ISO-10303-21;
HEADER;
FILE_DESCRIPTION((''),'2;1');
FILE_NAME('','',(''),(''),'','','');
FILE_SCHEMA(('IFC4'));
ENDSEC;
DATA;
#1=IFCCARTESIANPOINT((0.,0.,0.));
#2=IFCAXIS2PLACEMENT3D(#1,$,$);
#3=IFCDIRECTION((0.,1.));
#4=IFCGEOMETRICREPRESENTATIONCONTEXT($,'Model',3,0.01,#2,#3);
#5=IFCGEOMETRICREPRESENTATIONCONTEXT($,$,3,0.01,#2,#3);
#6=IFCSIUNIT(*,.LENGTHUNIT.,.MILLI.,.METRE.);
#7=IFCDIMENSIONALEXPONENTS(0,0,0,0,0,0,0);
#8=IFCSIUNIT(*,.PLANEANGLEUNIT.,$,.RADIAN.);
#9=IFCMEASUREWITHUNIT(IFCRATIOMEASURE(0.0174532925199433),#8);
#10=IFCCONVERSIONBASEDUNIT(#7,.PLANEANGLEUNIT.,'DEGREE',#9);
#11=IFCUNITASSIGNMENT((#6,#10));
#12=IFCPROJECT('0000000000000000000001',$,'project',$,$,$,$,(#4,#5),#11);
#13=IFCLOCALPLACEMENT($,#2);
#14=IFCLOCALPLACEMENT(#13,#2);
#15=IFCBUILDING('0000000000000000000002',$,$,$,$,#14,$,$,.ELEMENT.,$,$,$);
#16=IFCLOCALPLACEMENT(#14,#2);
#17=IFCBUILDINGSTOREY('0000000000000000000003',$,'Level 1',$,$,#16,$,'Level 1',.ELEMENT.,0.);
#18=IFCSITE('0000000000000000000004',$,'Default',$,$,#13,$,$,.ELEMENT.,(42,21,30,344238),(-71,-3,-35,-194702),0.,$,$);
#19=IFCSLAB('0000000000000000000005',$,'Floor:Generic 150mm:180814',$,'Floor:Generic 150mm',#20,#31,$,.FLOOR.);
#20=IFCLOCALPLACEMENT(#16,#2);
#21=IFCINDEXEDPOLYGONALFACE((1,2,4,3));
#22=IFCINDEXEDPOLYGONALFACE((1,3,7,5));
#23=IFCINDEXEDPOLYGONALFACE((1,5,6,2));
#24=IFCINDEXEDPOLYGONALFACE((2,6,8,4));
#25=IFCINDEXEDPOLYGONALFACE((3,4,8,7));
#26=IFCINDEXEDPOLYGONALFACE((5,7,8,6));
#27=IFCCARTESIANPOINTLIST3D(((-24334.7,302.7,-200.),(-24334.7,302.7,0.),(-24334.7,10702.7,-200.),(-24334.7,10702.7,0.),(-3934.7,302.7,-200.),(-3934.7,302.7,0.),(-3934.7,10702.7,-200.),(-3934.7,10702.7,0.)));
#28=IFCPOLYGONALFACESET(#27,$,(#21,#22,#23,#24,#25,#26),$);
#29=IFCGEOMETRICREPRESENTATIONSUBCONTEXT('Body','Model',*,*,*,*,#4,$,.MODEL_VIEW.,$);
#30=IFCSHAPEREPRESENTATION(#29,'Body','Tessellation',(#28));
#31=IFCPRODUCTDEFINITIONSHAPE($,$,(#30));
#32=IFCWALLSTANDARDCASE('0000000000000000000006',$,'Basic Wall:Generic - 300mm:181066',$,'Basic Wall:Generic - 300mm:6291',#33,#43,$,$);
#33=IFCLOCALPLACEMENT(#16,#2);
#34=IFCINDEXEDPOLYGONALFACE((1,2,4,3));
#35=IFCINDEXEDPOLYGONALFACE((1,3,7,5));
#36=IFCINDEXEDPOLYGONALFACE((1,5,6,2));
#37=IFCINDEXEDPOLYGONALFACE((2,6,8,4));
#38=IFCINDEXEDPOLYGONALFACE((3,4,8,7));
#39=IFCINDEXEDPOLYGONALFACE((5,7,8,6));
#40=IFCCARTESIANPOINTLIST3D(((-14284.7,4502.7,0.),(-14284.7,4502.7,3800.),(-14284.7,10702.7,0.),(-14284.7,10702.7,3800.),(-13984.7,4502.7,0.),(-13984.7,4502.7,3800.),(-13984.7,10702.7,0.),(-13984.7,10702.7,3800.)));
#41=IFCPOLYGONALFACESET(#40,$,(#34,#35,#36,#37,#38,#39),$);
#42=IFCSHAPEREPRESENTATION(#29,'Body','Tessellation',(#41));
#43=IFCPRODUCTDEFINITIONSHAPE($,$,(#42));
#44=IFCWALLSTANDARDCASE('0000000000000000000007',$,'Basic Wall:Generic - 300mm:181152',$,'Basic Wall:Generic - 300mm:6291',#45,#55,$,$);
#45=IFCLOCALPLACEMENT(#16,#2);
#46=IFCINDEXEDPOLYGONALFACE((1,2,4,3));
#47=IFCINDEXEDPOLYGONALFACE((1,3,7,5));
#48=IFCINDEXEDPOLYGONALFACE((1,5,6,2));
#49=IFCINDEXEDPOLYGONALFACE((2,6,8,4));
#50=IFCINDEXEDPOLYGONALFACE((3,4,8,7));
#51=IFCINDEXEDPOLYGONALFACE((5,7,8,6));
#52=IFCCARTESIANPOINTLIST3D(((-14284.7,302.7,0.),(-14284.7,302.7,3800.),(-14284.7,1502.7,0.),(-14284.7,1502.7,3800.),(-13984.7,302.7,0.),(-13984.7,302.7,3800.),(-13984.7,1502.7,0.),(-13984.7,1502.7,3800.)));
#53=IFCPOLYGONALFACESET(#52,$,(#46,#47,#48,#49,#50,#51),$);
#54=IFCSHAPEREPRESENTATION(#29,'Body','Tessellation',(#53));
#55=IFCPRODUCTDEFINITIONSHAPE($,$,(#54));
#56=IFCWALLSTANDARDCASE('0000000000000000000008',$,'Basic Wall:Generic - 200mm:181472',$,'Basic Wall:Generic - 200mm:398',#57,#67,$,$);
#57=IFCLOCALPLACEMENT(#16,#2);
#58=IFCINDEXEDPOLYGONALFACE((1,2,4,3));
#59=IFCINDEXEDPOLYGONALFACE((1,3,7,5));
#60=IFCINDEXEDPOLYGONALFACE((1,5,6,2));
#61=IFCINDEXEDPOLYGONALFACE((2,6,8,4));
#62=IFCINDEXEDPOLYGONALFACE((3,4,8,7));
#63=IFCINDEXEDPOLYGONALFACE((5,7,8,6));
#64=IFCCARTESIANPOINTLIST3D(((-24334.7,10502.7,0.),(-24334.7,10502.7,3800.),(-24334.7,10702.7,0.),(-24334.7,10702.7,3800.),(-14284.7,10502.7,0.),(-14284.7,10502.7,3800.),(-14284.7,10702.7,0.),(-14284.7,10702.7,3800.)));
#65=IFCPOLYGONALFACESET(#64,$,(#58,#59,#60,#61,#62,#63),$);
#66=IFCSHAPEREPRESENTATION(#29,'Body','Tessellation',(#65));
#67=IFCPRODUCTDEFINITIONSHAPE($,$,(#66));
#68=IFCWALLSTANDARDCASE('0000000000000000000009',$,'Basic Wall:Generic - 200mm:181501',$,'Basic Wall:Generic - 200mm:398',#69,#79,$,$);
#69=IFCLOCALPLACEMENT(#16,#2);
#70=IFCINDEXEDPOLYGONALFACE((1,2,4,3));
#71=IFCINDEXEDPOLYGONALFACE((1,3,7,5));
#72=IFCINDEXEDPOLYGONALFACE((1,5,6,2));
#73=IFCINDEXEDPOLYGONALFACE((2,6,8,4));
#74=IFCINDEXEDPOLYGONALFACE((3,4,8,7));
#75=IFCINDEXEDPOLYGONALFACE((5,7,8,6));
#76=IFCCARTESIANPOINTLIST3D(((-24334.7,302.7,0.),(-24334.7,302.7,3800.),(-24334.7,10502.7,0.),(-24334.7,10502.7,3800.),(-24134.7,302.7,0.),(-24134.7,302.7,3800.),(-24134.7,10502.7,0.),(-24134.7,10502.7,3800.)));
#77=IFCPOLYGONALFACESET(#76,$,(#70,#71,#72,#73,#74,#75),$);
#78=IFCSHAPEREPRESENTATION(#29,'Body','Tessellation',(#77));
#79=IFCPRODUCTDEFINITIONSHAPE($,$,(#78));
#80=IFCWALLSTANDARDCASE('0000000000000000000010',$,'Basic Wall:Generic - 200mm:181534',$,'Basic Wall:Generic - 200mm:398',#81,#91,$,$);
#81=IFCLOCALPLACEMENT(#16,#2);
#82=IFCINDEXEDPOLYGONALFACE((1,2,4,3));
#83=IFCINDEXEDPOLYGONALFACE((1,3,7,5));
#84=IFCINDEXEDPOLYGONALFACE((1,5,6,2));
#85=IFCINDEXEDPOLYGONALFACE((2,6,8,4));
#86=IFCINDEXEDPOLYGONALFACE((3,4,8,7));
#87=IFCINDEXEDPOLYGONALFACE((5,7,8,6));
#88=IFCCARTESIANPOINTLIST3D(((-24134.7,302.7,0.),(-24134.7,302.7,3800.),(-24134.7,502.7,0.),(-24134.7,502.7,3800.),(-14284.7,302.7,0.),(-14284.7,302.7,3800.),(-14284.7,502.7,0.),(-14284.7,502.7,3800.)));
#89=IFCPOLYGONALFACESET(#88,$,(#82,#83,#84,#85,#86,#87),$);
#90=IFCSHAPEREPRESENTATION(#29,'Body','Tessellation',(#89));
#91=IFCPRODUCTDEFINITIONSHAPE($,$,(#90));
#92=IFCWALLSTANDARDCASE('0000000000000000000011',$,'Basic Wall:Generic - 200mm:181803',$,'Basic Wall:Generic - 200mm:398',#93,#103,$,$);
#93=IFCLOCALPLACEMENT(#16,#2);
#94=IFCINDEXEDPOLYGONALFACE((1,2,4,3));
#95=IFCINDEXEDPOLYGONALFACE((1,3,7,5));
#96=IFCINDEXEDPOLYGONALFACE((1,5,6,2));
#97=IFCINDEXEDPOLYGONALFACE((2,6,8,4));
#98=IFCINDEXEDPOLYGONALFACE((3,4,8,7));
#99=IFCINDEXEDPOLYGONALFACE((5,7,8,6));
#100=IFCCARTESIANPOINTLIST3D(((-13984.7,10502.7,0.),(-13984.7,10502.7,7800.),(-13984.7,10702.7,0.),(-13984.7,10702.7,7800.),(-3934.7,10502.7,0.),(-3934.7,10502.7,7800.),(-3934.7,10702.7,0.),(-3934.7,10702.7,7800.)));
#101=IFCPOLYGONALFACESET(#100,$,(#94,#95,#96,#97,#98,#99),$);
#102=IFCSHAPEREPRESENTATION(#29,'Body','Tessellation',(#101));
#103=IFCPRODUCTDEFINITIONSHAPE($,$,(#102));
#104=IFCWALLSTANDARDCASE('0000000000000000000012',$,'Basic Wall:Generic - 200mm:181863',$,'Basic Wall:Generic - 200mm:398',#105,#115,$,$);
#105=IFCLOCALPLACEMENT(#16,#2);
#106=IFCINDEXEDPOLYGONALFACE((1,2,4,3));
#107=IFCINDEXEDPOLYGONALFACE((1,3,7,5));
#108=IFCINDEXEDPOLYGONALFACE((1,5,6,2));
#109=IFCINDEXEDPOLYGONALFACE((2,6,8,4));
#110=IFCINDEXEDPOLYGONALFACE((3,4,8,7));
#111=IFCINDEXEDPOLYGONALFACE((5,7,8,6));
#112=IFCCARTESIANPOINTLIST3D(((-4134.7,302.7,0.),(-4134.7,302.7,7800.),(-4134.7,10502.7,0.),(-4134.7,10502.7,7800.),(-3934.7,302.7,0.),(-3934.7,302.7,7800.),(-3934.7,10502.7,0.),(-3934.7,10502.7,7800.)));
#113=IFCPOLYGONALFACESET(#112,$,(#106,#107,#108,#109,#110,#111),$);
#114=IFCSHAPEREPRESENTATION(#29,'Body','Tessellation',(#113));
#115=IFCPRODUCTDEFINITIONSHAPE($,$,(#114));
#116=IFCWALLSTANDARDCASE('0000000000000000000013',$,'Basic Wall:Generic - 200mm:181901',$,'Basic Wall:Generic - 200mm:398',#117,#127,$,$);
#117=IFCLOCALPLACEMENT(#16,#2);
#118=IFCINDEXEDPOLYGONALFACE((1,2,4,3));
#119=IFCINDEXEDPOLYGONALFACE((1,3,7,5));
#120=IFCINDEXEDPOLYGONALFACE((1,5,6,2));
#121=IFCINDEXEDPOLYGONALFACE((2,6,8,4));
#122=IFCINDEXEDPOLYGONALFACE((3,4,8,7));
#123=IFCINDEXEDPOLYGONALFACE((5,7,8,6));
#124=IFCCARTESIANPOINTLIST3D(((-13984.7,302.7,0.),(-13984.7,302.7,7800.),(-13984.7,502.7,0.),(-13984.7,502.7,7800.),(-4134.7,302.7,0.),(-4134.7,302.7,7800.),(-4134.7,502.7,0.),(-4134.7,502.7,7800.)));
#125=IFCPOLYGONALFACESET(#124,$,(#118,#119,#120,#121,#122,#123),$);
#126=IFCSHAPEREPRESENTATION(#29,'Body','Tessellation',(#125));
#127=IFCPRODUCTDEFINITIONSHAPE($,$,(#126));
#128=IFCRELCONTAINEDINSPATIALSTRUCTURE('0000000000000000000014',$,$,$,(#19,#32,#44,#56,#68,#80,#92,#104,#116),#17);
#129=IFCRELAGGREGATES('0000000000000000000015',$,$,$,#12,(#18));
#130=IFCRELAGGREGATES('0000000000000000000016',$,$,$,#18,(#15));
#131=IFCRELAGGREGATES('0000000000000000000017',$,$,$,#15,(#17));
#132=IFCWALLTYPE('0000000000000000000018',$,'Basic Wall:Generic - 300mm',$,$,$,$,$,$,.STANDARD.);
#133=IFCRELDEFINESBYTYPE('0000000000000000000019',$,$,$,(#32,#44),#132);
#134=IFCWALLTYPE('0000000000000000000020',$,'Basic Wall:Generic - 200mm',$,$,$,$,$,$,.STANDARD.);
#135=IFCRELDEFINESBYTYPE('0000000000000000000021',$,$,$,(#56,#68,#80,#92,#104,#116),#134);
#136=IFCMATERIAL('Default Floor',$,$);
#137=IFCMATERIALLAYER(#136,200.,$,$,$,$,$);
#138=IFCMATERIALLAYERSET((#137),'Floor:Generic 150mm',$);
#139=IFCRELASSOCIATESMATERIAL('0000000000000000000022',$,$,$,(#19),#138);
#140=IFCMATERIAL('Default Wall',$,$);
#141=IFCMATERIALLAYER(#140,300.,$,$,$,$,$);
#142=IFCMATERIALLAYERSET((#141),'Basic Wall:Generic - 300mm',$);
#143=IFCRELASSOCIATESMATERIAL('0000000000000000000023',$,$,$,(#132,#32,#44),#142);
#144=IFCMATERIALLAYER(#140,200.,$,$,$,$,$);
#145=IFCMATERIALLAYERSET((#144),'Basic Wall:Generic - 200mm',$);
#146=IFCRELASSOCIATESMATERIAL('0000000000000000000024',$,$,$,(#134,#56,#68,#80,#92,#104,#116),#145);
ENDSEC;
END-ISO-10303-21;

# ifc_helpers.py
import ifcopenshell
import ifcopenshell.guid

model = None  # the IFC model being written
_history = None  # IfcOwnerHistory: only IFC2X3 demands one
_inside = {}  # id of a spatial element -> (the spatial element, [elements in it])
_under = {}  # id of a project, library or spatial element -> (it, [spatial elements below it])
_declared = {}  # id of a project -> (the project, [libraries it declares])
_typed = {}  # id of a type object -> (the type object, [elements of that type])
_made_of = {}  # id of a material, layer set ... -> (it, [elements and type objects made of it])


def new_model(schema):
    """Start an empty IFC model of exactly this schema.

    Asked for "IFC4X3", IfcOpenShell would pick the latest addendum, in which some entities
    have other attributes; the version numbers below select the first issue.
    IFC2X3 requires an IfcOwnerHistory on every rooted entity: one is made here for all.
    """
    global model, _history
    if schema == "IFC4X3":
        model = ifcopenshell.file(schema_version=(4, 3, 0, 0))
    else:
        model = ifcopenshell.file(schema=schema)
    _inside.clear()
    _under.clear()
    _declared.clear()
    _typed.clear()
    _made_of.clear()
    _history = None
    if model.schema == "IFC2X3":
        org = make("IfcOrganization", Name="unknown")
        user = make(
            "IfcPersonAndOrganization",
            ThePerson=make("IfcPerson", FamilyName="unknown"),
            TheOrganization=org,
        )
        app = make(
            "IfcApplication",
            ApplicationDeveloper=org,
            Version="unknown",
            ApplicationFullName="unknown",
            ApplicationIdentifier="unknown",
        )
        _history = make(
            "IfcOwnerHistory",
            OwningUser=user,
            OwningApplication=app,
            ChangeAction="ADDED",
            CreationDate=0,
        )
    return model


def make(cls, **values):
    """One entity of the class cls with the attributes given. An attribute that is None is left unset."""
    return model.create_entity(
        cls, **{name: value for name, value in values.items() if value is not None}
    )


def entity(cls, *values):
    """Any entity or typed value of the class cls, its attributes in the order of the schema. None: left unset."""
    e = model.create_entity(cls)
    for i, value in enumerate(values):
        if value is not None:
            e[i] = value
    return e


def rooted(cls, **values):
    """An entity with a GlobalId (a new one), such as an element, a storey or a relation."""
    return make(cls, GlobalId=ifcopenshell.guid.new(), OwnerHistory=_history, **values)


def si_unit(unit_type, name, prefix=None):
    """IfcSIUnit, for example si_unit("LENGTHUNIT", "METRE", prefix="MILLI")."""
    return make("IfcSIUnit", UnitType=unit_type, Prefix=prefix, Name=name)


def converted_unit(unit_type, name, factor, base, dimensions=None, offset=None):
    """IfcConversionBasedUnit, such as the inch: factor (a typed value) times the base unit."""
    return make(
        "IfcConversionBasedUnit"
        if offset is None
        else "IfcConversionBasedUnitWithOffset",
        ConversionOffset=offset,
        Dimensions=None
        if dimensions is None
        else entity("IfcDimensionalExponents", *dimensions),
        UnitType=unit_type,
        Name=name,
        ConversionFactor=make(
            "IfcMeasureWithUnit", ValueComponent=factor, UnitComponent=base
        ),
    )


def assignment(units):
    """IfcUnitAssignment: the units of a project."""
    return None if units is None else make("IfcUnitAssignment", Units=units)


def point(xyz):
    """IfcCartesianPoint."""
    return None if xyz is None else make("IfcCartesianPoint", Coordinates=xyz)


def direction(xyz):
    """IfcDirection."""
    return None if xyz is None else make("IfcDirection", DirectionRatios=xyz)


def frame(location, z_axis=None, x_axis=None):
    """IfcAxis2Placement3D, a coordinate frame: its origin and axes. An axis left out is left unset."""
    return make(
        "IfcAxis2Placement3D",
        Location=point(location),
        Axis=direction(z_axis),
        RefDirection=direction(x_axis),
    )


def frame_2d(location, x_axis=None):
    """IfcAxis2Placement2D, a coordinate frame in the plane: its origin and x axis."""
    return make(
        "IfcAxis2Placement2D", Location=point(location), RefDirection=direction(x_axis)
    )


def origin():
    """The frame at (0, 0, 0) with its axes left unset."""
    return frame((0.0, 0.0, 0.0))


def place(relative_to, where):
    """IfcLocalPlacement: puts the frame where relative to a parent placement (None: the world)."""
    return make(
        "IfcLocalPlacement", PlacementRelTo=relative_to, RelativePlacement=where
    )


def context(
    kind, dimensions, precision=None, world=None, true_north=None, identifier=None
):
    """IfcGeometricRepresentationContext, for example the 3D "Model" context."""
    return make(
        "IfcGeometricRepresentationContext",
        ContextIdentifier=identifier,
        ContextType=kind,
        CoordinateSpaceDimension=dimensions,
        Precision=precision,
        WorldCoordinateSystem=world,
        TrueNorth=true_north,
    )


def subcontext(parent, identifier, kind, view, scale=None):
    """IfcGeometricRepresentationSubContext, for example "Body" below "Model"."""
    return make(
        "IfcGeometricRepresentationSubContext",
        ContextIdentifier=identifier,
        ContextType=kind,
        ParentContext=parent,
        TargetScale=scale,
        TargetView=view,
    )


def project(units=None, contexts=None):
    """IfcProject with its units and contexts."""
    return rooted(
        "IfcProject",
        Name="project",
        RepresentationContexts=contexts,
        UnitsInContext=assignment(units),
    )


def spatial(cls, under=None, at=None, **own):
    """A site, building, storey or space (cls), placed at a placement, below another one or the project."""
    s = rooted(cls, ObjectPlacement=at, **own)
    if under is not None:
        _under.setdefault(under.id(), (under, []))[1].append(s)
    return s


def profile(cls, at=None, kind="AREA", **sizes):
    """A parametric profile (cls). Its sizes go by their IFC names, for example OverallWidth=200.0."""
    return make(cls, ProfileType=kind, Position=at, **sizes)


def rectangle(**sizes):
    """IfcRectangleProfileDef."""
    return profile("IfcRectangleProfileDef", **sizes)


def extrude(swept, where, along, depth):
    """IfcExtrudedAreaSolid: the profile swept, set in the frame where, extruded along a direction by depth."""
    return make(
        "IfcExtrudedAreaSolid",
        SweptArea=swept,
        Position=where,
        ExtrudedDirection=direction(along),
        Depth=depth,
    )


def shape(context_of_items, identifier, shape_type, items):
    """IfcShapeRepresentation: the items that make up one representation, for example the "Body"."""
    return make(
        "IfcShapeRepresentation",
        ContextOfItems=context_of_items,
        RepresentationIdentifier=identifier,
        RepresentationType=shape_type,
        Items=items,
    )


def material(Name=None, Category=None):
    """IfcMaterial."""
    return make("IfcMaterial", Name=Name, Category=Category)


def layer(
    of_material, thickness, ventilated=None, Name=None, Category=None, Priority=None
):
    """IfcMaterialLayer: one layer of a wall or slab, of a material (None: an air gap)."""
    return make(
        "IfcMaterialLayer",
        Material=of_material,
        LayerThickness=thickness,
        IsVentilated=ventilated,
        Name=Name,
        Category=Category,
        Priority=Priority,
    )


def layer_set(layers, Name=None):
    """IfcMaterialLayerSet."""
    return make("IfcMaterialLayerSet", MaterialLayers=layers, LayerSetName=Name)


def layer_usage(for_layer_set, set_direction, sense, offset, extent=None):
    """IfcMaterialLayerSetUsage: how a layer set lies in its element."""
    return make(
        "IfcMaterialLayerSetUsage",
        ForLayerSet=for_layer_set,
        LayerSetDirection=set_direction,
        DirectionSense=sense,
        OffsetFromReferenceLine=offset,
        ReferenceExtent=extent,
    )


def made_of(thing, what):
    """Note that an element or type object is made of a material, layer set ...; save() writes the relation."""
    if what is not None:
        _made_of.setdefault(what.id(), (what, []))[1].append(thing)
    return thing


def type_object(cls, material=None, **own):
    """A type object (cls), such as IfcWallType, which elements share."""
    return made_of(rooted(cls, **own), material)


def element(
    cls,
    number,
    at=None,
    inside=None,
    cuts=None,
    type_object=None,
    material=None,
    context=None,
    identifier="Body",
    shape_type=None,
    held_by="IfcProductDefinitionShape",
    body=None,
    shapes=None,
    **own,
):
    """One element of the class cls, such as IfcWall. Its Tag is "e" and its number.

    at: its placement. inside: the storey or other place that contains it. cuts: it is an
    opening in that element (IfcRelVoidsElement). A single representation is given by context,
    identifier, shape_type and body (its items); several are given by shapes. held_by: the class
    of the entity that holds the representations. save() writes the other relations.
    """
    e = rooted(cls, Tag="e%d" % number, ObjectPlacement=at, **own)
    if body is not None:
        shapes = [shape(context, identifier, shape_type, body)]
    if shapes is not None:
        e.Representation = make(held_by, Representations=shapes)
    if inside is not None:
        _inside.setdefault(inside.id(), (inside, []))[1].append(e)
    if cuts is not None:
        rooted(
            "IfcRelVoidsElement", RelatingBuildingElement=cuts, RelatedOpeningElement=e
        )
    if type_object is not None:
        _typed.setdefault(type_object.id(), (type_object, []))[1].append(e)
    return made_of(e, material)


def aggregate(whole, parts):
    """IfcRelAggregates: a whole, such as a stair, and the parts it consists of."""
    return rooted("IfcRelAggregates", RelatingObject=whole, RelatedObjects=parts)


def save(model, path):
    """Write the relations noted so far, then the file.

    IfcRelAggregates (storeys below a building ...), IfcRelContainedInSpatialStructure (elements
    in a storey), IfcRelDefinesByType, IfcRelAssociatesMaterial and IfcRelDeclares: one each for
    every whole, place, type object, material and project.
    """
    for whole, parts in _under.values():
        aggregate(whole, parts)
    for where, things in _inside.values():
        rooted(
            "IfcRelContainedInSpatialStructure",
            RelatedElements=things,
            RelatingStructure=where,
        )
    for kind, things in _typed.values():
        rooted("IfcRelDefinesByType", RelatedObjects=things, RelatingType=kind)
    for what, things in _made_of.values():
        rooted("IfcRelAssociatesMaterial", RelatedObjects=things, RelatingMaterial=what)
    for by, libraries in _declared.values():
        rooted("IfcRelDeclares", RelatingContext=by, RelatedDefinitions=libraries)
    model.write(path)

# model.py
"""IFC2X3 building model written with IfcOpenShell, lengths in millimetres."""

from ifc_helpers import new_model, entity, si_unit, converted_unit, direction, frame, frame_2d, origin, place, context, subcontext, project, spatial, rectangle, extrude, material, layer, layer_set, layer_usage, type_object, element, save


model = new_model("IFC2X3")

# Units and contexts
model_context = context("Model", 3, precision=0.01, world=origin(), true_north=direction((0.0, 1.0)))
context_of_model = context(None, 3, precision=0.01, world=origin(), true_north=direction((0.0, 1.0)))
body_context = subcontext(model_context, "Body", "Model", "MODEL_VIEW")
ifc_project = project(units=[si_unit("LENGTHUNIT", "METRE", prefix="MILLI"), converted_unit("PLANEANGLEUNIT", "DEGREE", entity("IfcRatioMeasure", 0.0174532925199433), si_unit("PLANEANGLEUNIT", "RADIAN"), dimensions=[0, 0, 0, 0, 0, 0, 0])], contexts=[model_context, context_of_model])

# Site, building, storey
site_placement = place(None, origin())
site = spatial("IfcSite", under=ifc_project, at=site_placement, Name="Default", CompositionType="ELEMENT", RefLatitude=(42, 21, 30, 344238), RefLongitude=(-71, -3, -35, -194702), RefElevation=0.0)
building_placement = place(site_placement, origin())
building = spatial("IfcBuilding", under=site, at=building_placement, CompositionType="ELEMENT")
storey_placement = place(building_placement, origin())
storey = spatial("IfcBuildingStorey", under=building, at=storey_placement, Name="Level 1", LongName="Level 1", CompositionType="ELEMENT", Elevation=0.0)

# Slab
ifc_material_1 = material(Name="Default Floor")
ifc_layer_1 = layer(ifc_material_1, 200.0)
ifc_layer_set_1 = layer_set([ifc_layer_1], Name="Floor:Generic 150mm")
ifc_layer_usage_1 = layer_usage(ifc_layer_set_1, "AXIS3", "POSITIVE", 0.0)
slab_placement = place(storey_placement, origin())
element("IfcSlab", 1, at=slab_placement, inside=storey, material=ifc_layer_usage_1, Name="Floor:Generic 150mm:180814", ObjectType="Floor:Generic 150mm", PredefinedType="FLOOR", context=body_context, shape_type="SweptSolid", body=[
    extrude(rectangle(XDim=10400.0, YDim=20400.0, at=frame_2d((0.0, 0.0), x_axis=(1.0, 0.0))), frame((-14134.7, 5502.7, 0.0), z_axis=(0.0, 0.0, -1.0), x_axis=(0.0, 1.0, 0.0)), (0.0, 0.0, 1.0), 200.0),
])

# Walls
ifc_material_2 = material(Name="Default Wall")
ifc_layer_2 = layer(ifc_material_2, 300.0)
ifc_layer_set_2 = layer_set([ifc_layer_2], Name="Basic Wall:Generic - 300mm")
ifc_layer_usage_2 = layer_usage(ifc_layer_set_2, "AXIS2", "NEGATIVE", 150.0)
wall_type_1 = type_object("IfcWallType", Name="Basic Wall:Generic - 300mm", PredefinedType="STANDARD", material=ifc_layer_set_2)
wall_1_placement = place(storey_placement, frame((-14134.7, 10702.7, 0.0), z_axis=(0.0, 0.0, 1.0), x_axis=(0.0, -1.0, 0.0)))
element("IfcWallStandardCase", 2, at=wall_1_placement, inside=storey, type_object=wall_type_1, material=ifc_layer_usage_2, Name="Basic Wall:Generic - 300mm:181066", ObjectType="Basic Wall:Generic - 300mm:6291", context=body_context, shape_type="SweptSolid", body=[
    extrude(rectangle(XDim=6200.0, YDim=300.0, at=frame_2d((3100.0, 0.0), x_axis=(-1.0, 0.0))), origin(), (0.0, 0.0, 1.0), 3800.0),
])
ifc_layer_usage_3 = layer_usage(ifc_layer_set_2, "AXIS2", "NEGATIVE", 150.0)
wall_2_placement = place(storey_placement, frame((-14134.7, 302.7, 0.0), z_axis=(0.0, 0.0, 1.0), x_axis=(0.0, 1.0, 0.0)))
element("IfcWallStandardCase", 3, at=wall_2_placement, inside=storey, type_object=wall_type_1, material=ifc_layer_usage_3, Name="Basic Wall:Generic - 300mm:181152", ObjectType="Basic Wall:Generic - 300mm:6291", context=body_context, shape_type="SweptSolid", body=[
    extrude(rectangle(XDim=1200.0, YDim=300.0, at=frame_2d((600.0, 0.0), x_axis=(-1.0, 0.0))), origin(), (0.0, 0.0, 1.0), 3800.0),
])
ifc_layer_3 = layer(ifc_material_2, 200.0)
ifc_layer_set_3 = layer_set([ifc_layer_3], Name="Basic Wall:Generic - 200mm")
ifc_layer_usage_4 = layer_usage(ifc_layer_set_3, "AXIS2", "NEGATIVE", 100.0)
wall_type_2 = type_object("IfcWallType", Name="Basic Wall:Generic - 200mm", PredefinedType="STANDARD", material=ifc_layer_set_3)
wall_3_placement = place(storey_placement, frame((-14284.7, 10602.7, 0.0), z_axis=(0.0, 0.0, 1.0), x_axis=(-1.0, 0.0, 0.0)))
element("IfcWallStandardCase", 4, at=wall_3_placement, inside=storey, type_object=wall_type_2, material=ifc_layer_usage_4, Name="Basic Wall:Generic - 200mm:181472", ObjectType="Basic Wall:Generic - 200mm:398", context=body_context, shape_type="SweptSolid", body=[
    extrude(rectangle(XDim=10050.0, YDim=200.0, at=frame_2d((5025.0, 0.0), x_axis=(-1.0, 0.0))), origin(), (0.0, 0.0, 1.0), 3800.0),
])
ifc_layer_usage_5 = layer_usage(ifc_layer_set_3, "AXIS2", "NEGATIVE", 100.0)
wall_4_placement = place(storey_placement, frame((-24234.7, 10502.7, 0.0), z_axis=(0.0, 0.0, 1.0), x_axis=(0.0, -1.0, 0.0)))
element("IfcWallStandardCase", 5, at=wall_4_placement, inside=storey, type_object=wall_type_2, material=ifc_layer_usage_5, Name="Basic Wall:Generic - 200mm:181501", ObjectType="Basic Wall:Generic - 200mm:398", context=body_context, shape_type="SweptSolid", body=[
    extrude(rectangle(XDim=10200.0, YDim=200.0, at=frame_2d((5100.0, 0.0), x_axis=(-1.0, 0.0))), origin(), (0.0, 0.0, 1.0), 3800.0),
])
ifc_layer_usage_6 = layer_usage(ifc_layer_set_3, "AXIS2", "NEGATIVE", 100.0)
wall_5_placement = place(storey_placement, frame((-24134.7, 402.7, 0.0)))
element("IfcWallStandardCase", 6, at=wall_5_placement, inside=storey, type_object=wall_type_2, material=ifc_layer_usage_6, Name="Basic Wall:Generic - 200mm:181534", ObjectType="Basic Wall:Generic - 200mm:398", context=body_context, shape_type="SweptSolid", body=[
    extrude(rectangle(XDim=9850.0, YDim=200.0, at=frame_2d((4925.0, 0.0), x_axis=(-1.0, 0.0))), origin(), (0.0, 0.0, 1.0), 3800.0),
])
ifc_layer_usage_7 = layer_usage(ifc_layer_set_3, "AXIS2", "NEGATIVE", 100.0)
wall_6_placement = place(storey_placement, frame((-13984.7, 10602.7, 0.0)))
element("IfcWallStandardCase", 7, at=wall_6_placement, inside=storey, type_object=wall_type_2, material=ifc_layer_usage_7, Name="Basic Wall:Generic - 200mm:181803", ObjectType="Basic Wall:Generic - 200mm:398", context=body_context, shape_type="SweptSolid", body=[
    extrude(rectangle(XDim=10050.0, YDim=200.0, at=frame_2d((5025.0, 0.0), x_axis=(-1.0, 0.0))), origin(), (0.0, 0.0, 1.0), 7800.0),
])
ifc_layer_usage_8 = layer_usage(ifc_layer_set_3, "AXIS2", "NEGATIVE", 100.0)
wall_7_placement = place(storey_placement, frame((-4034.7, 10502.7, 0.0), z_axis=(0.0, 0.0, 1.0), x_axis=(0.0, -1.0, 0.0)))
element("IfcWallStandardCase", 8, at=wall_7_placement, inside=storey, type_object=wall_type_2, material=ifc_layer_usage_8, Name="Basic Wall:Generic - 200mm:181863", ObjectType="Basic Wall:Generic - 200mm:398", context=body_context, shape_type="SweptSolid", body=[
    extrude(rectangle(XDim=10200.0, YDim=200.0, at=frame_2d((5100.0, 0.0), x_axis=(-1.0, 0.0))), origin(), (0.0, 0.0, 1.0), 7800.0),
])
ifc_layer_usage_9 = layer_usage(ifc_layer_set_3, "AXIS2", "NEGATIVE", 100.0)
wall_8_placement = place(storey_placement, frame((-4134.7, 402.7, 0.0), z_axis=(0.0, 0.0, 1.0), x_axis=(-1.0, 0.0, 0.0)))
element("IfcWallStandardCase", 9, at=wall_8_placement, inside=storey, type_object=wall_type_2, material=ifc_layer_usage_9, Name="Basic Wall:Generic - 200mm:181901", ObjectType="Basic Wall:Generic - 200mm:398", context=body_context, shape_type="SweptSolid", body=[
    extrude(rectangle(XDim=9850.0, YDim=200.0, at=frame_2d((4925.0, 0.0), x_axis=(-1.0, 0.0))), origin(), (0.0, 0.0, 1.0), 7800.0),
])

save(model, "model.ifc")
